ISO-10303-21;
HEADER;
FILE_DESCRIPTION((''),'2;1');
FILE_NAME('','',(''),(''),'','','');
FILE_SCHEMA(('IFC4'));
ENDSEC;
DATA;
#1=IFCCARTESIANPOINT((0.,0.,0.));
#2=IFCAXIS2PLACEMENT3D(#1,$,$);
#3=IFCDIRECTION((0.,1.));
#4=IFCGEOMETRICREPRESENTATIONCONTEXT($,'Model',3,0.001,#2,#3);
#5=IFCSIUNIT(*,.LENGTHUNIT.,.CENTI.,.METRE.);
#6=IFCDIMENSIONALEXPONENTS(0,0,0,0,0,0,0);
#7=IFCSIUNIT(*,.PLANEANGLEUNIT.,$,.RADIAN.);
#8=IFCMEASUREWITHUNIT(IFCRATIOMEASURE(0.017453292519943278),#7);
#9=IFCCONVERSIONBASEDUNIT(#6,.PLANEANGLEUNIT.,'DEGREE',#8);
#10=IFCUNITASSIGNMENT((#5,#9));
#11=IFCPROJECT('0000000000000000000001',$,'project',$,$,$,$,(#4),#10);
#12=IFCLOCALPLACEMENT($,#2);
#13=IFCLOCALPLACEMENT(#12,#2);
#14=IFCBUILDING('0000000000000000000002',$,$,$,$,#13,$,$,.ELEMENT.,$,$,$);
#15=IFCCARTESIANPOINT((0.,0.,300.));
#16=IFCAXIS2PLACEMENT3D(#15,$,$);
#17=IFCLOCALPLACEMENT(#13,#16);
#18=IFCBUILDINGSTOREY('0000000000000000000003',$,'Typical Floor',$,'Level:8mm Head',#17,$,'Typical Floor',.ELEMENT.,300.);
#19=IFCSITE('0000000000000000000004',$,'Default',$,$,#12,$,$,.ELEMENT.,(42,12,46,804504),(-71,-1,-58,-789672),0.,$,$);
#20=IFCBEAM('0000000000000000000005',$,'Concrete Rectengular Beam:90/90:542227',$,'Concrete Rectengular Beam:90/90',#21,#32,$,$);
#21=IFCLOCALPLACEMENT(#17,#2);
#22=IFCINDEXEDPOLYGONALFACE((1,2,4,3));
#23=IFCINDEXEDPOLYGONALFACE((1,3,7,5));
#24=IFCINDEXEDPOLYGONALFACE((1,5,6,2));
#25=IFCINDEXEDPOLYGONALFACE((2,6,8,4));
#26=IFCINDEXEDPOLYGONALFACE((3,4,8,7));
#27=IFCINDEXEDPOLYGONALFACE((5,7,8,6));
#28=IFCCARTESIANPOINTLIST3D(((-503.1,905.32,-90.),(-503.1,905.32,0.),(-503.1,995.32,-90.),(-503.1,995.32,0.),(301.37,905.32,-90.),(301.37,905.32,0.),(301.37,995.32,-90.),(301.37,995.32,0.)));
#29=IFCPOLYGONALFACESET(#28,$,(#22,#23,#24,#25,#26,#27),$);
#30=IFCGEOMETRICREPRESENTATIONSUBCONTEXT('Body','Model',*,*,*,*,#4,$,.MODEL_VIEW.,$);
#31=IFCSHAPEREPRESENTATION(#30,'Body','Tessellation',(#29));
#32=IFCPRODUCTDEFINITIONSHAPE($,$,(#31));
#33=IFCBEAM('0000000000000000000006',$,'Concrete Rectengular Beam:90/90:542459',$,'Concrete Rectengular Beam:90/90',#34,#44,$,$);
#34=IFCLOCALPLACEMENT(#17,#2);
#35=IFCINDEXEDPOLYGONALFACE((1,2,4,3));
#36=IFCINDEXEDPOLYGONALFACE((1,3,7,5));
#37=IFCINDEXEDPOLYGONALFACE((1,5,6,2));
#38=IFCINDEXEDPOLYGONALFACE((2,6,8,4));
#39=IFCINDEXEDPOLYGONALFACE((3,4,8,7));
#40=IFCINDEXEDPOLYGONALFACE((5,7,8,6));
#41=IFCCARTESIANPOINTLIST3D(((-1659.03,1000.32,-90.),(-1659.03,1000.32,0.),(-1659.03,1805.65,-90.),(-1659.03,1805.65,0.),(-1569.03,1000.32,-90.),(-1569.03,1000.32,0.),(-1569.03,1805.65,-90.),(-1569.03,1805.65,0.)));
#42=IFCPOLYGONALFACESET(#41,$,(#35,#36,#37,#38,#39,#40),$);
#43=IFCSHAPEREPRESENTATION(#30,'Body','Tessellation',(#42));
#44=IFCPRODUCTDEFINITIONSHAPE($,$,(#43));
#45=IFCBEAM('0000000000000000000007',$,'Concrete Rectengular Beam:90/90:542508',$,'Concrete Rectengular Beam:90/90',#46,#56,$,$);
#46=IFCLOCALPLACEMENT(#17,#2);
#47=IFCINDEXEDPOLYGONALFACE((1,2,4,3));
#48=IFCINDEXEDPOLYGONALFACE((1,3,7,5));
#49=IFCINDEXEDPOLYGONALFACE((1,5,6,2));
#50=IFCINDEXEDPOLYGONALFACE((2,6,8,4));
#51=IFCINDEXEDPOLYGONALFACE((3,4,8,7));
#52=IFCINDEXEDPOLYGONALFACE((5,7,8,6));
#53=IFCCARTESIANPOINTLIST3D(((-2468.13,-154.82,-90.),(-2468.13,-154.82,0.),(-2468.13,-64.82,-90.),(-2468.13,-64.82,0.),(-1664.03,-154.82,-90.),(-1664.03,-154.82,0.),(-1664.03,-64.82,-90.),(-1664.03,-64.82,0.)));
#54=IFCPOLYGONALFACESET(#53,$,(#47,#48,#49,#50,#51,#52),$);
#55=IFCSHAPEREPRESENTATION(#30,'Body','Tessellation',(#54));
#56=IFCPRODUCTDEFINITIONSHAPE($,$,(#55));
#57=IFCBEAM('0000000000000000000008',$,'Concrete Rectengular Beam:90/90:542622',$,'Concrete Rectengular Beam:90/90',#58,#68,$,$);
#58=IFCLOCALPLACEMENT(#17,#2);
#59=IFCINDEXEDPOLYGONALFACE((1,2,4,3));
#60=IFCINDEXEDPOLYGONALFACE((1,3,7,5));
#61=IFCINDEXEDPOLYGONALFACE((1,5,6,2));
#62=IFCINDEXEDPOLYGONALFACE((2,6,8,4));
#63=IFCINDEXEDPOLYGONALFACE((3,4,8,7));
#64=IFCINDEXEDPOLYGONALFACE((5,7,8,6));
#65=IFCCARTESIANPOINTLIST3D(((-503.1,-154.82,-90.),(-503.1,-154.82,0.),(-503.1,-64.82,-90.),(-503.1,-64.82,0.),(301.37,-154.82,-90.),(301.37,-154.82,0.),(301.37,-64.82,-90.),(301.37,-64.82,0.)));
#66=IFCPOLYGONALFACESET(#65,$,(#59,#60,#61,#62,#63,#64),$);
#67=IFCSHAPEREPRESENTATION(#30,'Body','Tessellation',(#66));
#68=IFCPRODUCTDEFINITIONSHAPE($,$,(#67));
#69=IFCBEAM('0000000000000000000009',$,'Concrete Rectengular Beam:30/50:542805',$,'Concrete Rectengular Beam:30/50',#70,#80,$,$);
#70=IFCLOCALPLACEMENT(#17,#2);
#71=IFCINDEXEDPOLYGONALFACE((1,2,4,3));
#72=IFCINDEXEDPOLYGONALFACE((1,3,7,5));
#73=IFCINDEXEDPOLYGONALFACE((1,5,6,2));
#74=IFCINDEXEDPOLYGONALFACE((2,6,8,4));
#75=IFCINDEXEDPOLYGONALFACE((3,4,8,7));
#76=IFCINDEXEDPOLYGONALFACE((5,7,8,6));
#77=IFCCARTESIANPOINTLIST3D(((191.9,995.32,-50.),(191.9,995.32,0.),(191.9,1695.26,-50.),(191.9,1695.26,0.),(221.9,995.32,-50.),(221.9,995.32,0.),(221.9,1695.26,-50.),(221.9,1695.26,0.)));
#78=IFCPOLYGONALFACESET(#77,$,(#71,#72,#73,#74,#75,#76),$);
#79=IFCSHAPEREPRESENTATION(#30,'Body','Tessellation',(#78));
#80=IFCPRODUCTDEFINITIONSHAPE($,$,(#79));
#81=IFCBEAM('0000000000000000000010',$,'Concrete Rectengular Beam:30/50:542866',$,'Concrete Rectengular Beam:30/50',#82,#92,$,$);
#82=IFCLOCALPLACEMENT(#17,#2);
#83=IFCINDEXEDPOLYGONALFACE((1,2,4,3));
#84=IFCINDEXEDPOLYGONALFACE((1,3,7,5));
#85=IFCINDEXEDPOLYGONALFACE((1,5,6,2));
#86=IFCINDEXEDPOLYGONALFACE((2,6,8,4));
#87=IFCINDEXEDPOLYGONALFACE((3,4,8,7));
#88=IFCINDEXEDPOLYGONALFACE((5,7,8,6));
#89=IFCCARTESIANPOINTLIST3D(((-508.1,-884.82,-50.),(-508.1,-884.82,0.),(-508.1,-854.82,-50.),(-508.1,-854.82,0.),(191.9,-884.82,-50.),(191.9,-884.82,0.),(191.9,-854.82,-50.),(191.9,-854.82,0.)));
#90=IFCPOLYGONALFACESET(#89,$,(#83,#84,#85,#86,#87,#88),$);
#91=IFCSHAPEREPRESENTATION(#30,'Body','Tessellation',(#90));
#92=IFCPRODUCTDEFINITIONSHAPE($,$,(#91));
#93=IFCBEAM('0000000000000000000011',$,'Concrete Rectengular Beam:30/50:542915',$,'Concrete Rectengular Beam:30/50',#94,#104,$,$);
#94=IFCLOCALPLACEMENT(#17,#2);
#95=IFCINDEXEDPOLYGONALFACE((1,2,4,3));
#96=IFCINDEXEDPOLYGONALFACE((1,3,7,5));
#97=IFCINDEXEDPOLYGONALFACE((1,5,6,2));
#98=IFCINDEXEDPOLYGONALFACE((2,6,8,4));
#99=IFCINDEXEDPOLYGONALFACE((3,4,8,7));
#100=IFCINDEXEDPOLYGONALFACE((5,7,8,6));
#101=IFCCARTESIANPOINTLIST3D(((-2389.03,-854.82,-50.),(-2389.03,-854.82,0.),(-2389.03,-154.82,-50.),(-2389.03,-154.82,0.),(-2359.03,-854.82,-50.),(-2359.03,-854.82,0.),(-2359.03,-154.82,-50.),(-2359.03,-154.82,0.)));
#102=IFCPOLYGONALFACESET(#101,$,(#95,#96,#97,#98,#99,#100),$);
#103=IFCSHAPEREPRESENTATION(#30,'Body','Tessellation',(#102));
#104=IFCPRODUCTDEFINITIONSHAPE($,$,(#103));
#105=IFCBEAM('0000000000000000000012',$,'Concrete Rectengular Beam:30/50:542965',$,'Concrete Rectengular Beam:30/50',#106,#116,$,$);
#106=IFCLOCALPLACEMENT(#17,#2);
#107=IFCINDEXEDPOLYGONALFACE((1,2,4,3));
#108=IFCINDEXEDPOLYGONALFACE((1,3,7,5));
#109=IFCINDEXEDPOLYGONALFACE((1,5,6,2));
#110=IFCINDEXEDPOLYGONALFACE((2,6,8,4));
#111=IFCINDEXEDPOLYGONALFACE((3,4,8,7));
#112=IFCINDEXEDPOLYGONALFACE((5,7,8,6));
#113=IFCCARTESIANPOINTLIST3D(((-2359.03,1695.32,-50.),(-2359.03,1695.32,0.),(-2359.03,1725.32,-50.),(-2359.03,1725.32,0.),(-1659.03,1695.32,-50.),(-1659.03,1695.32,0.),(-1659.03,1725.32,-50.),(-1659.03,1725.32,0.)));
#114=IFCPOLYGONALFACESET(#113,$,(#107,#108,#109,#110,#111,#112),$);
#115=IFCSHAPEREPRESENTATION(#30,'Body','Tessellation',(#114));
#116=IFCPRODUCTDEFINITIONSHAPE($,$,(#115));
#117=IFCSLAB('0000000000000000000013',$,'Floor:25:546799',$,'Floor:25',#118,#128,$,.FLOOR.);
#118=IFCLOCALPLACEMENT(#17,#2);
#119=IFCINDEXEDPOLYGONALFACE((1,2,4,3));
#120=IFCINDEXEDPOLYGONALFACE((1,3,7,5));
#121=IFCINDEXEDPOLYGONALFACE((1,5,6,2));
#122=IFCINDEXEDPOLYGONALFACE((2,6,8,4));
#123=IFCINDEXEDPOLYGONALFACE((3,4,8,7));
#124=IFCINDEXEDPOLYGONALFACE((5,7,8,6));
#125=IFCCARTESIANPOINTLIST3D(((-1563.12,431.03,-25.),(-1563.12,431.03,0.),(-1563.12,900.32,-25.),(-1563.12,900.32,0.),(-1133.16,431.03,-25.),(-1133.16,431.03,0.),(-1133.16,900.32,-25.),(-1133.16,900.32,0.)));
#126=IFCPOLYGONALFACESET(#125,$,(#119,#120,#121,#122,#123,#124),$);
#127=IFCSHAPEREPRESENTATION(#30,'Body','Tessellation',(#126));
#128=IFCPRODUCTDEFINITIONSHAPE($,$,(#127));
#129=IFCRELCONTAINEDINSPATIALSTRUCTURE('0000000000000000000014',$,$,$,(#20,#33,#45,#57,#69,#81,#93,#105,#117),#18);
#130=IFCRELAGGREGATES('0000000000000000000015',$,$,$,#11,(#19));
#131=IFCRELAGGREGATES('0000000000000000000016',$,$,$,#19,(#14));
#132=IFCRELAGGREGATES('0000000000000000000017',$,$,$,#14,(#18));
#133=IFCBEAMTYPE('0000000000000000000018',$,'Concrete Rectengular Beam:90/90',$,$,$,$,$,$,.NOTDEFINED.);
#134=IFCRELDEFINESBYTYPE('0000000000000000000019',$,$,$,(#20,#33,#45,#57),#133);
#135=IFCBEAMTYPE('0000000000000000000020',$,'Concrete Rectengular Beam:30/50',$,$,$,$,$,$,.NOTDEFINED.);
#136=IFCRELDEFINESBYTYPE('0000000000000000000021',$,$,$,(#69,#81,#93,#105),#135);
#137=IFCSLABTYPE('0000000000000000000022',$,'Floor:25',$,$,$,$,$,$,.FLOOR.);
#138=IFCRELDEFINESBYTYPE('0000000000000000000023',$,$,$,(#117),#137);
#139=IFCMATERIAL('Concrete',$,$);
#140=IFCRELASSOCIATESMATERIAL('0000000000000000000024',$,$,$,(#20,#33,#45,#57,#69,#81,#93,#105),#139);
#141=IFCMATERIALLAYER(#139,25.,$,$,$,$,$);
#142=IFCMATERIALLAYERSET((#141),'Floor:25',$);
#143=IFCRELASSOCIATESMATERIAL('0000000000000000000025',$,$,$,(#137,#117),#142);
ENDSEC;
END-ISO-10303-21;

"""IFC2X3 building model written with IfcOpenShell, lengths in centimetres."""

from ifc_helpers import new_model, entity, si_unit, converted_unit, direction, frame, frame_2d, origin, place, context, subcontext, project, spatial, rectangle, extrude, material, layer, layer_set, layer_usage, type_object, element, save


model = new_model("IFC2X3")

# Units and contexts
model_context = context("Model", 3, precision=0.001, world=origin(), true_north=direction((0.0, 1.0)))
body_context = subcontext(model_context, "Body", "Model", "MODEL_VIEW")
ifc_project = project(units=[si_unit("LENGTHUNIT", "METRE", prefix="CENTI"), converted_unit("PLANEANGLEUNIT", "DEGREE", entity("IfcRatioMeasure", 0.017453292519943278), si_unit("PLANEANGLEUNIT", "RADIAN"), dimensions=[0, 0, 0, 0, 0, 0, 0])], contexts=[model_context])

# Site, building, storey
site_placement = place(None, origin())
site = spatial("IfcSite", under=ifc_project, at=site_placement, Name="Default", CompositionType="ELEMENT", RefLatitude=(42, 12, 46, 804504), RefLongitude=(-71, -1, -58, -789672), RefElevation=0.0)
building_placement = place(site_placement, origin())
building = spatial("IfcBuilding", under=site, at=building_placement, CompositionType="ELEMENT")
storey_placement = place(building_placement, frame((0.0, 0.0, 300.0)))
storey = spatial("IfcBuildingStorey", under=building, at=storey_placement, Name="Typical Floor", ObjectType="Level:8mm Head", LongName="Typical Floor", CompositionType="ELEMENT", Elevation=300.0)

# Beams
ifc_material = material(Name="Concrete")
beam_type_1 = type_object("IfcBeamType", Name="Concrete Rectengular Beam:90/90", PredefinedType="NOTDEFINED")
beam_1_placement = place(storey_placement, frame((346.37, 950.32, 0.0), z_axis=(0.0, 0.0, 1.0), x_axis=(-1.0, 0.0, 0.0)))
element("IfcBeam", 1, at=beam_1_placement, inside=storey, type_object=beam_type_1, material=ifc_material, Name="Concrete Rectengular Beam:90/90:542227", ObjectType="Concrete Rectengular Beam:90/90", context=body_context, shape_type="SweptSolid", body=[
    extrude(rectangle(XDim=90.0, YDim=90.0, at=frame_2d((0.0, 0.0), x_axis=(1.0, 0.0))), frame((45.0, 0.0, -45.0), z_axis=(1.0, 0.0, 0.0), x_axis=(0.0, 0.0, -1.0)), (0.0, 0.0, 1.0), 804.47),
])
beam_2_placement = place(storey_placement, frame((-1614.03, 1850.65, 0.0), z_axis=(0.0, 0.0, 1.0), x_axis=(0.0, -1.0, 0.0)))
element("IfcBeam", 2, at=beam_2_placement, inside=storey, type_object=beam_type_1, material=ifc_material, Name="Concrete Rectengular Beam:90/90:542459", ObjectType="Concrete Rectengular Beam:90/90", context=body_context, shape_type="SweptSolid", body=[
    extrude(rectangle(XDim=90.0, YDim=90.0, at=frame_2d((0.0, 0.0), x_axis=(1.0, 0.0))), frame((45.0, 0.0, -45.0), z_axis=(1.0, 0.0, 0.0), x_axis=(0.0, 0.0, -1.0)), (0.0, 0.0, 1.0), 805.33),
])
beam_3_placement = place(storey_placement, frame((-2513.13, -109.82, 0.0)))
element("IfcBeam", 3, at=beam_3_placement, inside=storey, type_object=beam_type_1, material=ifc_material, Name="Concrete Rectengular Beam:90/90:542508", ObjectType="Concrete Rectengular Beam:90/90", context=body_context, shape_type="SweptSolid", body=[
    extrude(rectangle(XDim=90.0, YDim=90.0, at=frame_2d((0.0, 0.0), x_axis=(1.0, 0.0))), frame((45.0, 0.0, -45.0), z_axis=(1.0, 0.0, 0.0), x_axis=(0.0, 0.0, -1.0)), (0.0, 0.0, 1.0), 804.1),
])
beam_4_placement = place(storey_placement, frame((346.37, -109.82, 0.0), z_axis=(0.0, 0.0, 1.0), x_axis=(-1.0, 0.0, 0.0)))
element("IfcBeam", 4, at=beam_4_placement, inside=storey, type_object=beam_type_1, material=ifc_material, Name="Concrete Rectengular Beam:90/90:542622", ObjectType="Concrete Rectengular Beam:90/90", context=body_context, shape_type="SweptSolid", body=[
    extrude(rectangle(XDim=90.0, YDim=90.0, at=frame_2d((0.0, 0.0), x_axis=(1.0, 0.0))), frame((45.0, 0.0, -45.0), z_axis=(1.0, 0.0, 0.0), x_axis=(0.0, 0.0, -1.0)), (0.0, 0.0, 1.0), 804.47),
])
beam_type_2 = type_object("IfcBeamType", Name="Concrete Rectengular Beam:30/50", PredefinedType="NOTDEFINED")
beam_5_placement = place(storey_placement, frame((206.9, 1710.26, 0.0), z_axis=(0.0, 0.0, 1.0), x_axis=(0.0, -1.0, 0.0)))
element("IfcBeam", 5, at=beam_5_placement, inside=storey, type_object=beam_type_2, material=ifc_material, Name="Concrete Rectengular Beam:30/50:542805", ObjectType="Concrete Rectengular Beam:30/50", context=body_context, shape_type="SweptSolid", body=[
    extrude(rectangle(XDim=50.0, YDim=30.0, at=frame_2d((0.0, 0.0), x_axis=(1.0, 0.0))), frame((15.0, 0.0, -25.0), z_axis=(1.0, 0.0, 0.0), x_axis=(0.0, 0.0, -1.0)), (0.0, 0.0, 1.0), 699.94),
])
beam_6_placement = place(storey_placement, frame((206.9, -869.82, 0.0), z_axis=(0.0, 0.0, 1.0), x_axis=(-1.0, 0.0, 0.0)))
element("IfcBeam", 6, at=beam_6_placement, inside=storey, type_object=beam_type_2, material=ifc_material, Name="Concrete Rectengular Beam:30/50:542866", ObjectType="Concrete Rectengular Beam:30/50", context=body_context, shape_type="SweptSolid", body=[
    extrude(rectangle(XDim=50.0, YDim=30.0, at=frame_2d((0.0, 0.0), x_axis=(1.0, 0.0))), frame((15.0, 0.0, -25.0), z_axis=(1.0, 0.0, 0.0), x_axis=(0.0, 0.0, -1.0)), (0.0, 0.0, 1.0), 700.0),
])
beam_7_placement = place(storey_placement, frame((-2374.03, -869.82, 0.0), z_axis=(0.0, 0.0, 1.0), x_axis=(0.0, 1.0, 0.0)))
element("IfcBeam", 7, at=beam_7_placement, inside=storey, type_object=beam_type_2, material=ifc_material, Name="Concrete Rectengular Beam:30/50:542915", ObjectType="Concrete Rectengular Beam:30/50", context=body_context, shape_type="SweptSolid", body=[
    extrude(rectangle(XDim=50.0, YDim=30.0, at=frame_2d((0.0, 0.0), x_axis=(1.0, 0.0))), frame((15.0, 0.0, -25.0), z_axis=(1.0, 0.0, 0.0), x_axis=(0.0, 0.0, -1.0)), (0.0, 0.0, 1.0), 700.0),
])
beam_8_placement = place(storey_placement, frame((-2374.03, 1710.32, 0.0)))
element("IfcBeam", 8, at=beam_8_placement, inside=storey, type_object=beam_type_2, material=ifc_material, Name="Concrete Rectengular Beam:30/50:542965", ObjectType="Concrete Rectengular Beam:30/50", context=body_context, shape_type="SweptSolid", body=[
    extrude(rectangle(XDim=50.0, YDim=30.0, at=frame_2d((0.0, 0.0), x_axis=(1.0, 0.0))), frame((15.0, 0.0, -25.0), z_axis=(1.0, 0.0, 0.0), x_axis=(0.0, 0.0, -1.0)), (0.0, 0.0, 1.0), 700.0),
])

# Slab
ifc_layer = layer(ifc_material, 25.0)
ifc_layer_set = layer_set([ifc_layer], Name="Floor:25")
ifc_layer_usage_1 = layer_usage(ifc_layer_set, "AXIS3", "POSITIVE", 0.0)
slab_type_1 = type_object("IfcSlabType", Name="Floor:25", PredefinedType="FLOOR", material=ifc_layer_set)
slab_1_placement = place(storey_placement, origin())
element("IfcSlab", 9, at=slab_1_placement, inside=storey, type_object=slab_type_1, material=ifc_layer_usage_1, Name="Floor:25:546799", ObjectType="Floor:25", PredefinedType="FLOOR", context=body_context, shape_type="SweptSolid", body=[
    extrude(rectangle(XDim=469.28, YDim=429.96, at=frame_2d((0.0, 0.0), x_axis=(1.0, 0.0))), frame((-1348.14, 665.68, 0.0), z_axis=(0.0, 0.0, -1.0), x_axis=(0.0, 1.0, 0.0)), (0.0, 0.0, 1.0), 25.0),
])

save(model, "model.ifc")
